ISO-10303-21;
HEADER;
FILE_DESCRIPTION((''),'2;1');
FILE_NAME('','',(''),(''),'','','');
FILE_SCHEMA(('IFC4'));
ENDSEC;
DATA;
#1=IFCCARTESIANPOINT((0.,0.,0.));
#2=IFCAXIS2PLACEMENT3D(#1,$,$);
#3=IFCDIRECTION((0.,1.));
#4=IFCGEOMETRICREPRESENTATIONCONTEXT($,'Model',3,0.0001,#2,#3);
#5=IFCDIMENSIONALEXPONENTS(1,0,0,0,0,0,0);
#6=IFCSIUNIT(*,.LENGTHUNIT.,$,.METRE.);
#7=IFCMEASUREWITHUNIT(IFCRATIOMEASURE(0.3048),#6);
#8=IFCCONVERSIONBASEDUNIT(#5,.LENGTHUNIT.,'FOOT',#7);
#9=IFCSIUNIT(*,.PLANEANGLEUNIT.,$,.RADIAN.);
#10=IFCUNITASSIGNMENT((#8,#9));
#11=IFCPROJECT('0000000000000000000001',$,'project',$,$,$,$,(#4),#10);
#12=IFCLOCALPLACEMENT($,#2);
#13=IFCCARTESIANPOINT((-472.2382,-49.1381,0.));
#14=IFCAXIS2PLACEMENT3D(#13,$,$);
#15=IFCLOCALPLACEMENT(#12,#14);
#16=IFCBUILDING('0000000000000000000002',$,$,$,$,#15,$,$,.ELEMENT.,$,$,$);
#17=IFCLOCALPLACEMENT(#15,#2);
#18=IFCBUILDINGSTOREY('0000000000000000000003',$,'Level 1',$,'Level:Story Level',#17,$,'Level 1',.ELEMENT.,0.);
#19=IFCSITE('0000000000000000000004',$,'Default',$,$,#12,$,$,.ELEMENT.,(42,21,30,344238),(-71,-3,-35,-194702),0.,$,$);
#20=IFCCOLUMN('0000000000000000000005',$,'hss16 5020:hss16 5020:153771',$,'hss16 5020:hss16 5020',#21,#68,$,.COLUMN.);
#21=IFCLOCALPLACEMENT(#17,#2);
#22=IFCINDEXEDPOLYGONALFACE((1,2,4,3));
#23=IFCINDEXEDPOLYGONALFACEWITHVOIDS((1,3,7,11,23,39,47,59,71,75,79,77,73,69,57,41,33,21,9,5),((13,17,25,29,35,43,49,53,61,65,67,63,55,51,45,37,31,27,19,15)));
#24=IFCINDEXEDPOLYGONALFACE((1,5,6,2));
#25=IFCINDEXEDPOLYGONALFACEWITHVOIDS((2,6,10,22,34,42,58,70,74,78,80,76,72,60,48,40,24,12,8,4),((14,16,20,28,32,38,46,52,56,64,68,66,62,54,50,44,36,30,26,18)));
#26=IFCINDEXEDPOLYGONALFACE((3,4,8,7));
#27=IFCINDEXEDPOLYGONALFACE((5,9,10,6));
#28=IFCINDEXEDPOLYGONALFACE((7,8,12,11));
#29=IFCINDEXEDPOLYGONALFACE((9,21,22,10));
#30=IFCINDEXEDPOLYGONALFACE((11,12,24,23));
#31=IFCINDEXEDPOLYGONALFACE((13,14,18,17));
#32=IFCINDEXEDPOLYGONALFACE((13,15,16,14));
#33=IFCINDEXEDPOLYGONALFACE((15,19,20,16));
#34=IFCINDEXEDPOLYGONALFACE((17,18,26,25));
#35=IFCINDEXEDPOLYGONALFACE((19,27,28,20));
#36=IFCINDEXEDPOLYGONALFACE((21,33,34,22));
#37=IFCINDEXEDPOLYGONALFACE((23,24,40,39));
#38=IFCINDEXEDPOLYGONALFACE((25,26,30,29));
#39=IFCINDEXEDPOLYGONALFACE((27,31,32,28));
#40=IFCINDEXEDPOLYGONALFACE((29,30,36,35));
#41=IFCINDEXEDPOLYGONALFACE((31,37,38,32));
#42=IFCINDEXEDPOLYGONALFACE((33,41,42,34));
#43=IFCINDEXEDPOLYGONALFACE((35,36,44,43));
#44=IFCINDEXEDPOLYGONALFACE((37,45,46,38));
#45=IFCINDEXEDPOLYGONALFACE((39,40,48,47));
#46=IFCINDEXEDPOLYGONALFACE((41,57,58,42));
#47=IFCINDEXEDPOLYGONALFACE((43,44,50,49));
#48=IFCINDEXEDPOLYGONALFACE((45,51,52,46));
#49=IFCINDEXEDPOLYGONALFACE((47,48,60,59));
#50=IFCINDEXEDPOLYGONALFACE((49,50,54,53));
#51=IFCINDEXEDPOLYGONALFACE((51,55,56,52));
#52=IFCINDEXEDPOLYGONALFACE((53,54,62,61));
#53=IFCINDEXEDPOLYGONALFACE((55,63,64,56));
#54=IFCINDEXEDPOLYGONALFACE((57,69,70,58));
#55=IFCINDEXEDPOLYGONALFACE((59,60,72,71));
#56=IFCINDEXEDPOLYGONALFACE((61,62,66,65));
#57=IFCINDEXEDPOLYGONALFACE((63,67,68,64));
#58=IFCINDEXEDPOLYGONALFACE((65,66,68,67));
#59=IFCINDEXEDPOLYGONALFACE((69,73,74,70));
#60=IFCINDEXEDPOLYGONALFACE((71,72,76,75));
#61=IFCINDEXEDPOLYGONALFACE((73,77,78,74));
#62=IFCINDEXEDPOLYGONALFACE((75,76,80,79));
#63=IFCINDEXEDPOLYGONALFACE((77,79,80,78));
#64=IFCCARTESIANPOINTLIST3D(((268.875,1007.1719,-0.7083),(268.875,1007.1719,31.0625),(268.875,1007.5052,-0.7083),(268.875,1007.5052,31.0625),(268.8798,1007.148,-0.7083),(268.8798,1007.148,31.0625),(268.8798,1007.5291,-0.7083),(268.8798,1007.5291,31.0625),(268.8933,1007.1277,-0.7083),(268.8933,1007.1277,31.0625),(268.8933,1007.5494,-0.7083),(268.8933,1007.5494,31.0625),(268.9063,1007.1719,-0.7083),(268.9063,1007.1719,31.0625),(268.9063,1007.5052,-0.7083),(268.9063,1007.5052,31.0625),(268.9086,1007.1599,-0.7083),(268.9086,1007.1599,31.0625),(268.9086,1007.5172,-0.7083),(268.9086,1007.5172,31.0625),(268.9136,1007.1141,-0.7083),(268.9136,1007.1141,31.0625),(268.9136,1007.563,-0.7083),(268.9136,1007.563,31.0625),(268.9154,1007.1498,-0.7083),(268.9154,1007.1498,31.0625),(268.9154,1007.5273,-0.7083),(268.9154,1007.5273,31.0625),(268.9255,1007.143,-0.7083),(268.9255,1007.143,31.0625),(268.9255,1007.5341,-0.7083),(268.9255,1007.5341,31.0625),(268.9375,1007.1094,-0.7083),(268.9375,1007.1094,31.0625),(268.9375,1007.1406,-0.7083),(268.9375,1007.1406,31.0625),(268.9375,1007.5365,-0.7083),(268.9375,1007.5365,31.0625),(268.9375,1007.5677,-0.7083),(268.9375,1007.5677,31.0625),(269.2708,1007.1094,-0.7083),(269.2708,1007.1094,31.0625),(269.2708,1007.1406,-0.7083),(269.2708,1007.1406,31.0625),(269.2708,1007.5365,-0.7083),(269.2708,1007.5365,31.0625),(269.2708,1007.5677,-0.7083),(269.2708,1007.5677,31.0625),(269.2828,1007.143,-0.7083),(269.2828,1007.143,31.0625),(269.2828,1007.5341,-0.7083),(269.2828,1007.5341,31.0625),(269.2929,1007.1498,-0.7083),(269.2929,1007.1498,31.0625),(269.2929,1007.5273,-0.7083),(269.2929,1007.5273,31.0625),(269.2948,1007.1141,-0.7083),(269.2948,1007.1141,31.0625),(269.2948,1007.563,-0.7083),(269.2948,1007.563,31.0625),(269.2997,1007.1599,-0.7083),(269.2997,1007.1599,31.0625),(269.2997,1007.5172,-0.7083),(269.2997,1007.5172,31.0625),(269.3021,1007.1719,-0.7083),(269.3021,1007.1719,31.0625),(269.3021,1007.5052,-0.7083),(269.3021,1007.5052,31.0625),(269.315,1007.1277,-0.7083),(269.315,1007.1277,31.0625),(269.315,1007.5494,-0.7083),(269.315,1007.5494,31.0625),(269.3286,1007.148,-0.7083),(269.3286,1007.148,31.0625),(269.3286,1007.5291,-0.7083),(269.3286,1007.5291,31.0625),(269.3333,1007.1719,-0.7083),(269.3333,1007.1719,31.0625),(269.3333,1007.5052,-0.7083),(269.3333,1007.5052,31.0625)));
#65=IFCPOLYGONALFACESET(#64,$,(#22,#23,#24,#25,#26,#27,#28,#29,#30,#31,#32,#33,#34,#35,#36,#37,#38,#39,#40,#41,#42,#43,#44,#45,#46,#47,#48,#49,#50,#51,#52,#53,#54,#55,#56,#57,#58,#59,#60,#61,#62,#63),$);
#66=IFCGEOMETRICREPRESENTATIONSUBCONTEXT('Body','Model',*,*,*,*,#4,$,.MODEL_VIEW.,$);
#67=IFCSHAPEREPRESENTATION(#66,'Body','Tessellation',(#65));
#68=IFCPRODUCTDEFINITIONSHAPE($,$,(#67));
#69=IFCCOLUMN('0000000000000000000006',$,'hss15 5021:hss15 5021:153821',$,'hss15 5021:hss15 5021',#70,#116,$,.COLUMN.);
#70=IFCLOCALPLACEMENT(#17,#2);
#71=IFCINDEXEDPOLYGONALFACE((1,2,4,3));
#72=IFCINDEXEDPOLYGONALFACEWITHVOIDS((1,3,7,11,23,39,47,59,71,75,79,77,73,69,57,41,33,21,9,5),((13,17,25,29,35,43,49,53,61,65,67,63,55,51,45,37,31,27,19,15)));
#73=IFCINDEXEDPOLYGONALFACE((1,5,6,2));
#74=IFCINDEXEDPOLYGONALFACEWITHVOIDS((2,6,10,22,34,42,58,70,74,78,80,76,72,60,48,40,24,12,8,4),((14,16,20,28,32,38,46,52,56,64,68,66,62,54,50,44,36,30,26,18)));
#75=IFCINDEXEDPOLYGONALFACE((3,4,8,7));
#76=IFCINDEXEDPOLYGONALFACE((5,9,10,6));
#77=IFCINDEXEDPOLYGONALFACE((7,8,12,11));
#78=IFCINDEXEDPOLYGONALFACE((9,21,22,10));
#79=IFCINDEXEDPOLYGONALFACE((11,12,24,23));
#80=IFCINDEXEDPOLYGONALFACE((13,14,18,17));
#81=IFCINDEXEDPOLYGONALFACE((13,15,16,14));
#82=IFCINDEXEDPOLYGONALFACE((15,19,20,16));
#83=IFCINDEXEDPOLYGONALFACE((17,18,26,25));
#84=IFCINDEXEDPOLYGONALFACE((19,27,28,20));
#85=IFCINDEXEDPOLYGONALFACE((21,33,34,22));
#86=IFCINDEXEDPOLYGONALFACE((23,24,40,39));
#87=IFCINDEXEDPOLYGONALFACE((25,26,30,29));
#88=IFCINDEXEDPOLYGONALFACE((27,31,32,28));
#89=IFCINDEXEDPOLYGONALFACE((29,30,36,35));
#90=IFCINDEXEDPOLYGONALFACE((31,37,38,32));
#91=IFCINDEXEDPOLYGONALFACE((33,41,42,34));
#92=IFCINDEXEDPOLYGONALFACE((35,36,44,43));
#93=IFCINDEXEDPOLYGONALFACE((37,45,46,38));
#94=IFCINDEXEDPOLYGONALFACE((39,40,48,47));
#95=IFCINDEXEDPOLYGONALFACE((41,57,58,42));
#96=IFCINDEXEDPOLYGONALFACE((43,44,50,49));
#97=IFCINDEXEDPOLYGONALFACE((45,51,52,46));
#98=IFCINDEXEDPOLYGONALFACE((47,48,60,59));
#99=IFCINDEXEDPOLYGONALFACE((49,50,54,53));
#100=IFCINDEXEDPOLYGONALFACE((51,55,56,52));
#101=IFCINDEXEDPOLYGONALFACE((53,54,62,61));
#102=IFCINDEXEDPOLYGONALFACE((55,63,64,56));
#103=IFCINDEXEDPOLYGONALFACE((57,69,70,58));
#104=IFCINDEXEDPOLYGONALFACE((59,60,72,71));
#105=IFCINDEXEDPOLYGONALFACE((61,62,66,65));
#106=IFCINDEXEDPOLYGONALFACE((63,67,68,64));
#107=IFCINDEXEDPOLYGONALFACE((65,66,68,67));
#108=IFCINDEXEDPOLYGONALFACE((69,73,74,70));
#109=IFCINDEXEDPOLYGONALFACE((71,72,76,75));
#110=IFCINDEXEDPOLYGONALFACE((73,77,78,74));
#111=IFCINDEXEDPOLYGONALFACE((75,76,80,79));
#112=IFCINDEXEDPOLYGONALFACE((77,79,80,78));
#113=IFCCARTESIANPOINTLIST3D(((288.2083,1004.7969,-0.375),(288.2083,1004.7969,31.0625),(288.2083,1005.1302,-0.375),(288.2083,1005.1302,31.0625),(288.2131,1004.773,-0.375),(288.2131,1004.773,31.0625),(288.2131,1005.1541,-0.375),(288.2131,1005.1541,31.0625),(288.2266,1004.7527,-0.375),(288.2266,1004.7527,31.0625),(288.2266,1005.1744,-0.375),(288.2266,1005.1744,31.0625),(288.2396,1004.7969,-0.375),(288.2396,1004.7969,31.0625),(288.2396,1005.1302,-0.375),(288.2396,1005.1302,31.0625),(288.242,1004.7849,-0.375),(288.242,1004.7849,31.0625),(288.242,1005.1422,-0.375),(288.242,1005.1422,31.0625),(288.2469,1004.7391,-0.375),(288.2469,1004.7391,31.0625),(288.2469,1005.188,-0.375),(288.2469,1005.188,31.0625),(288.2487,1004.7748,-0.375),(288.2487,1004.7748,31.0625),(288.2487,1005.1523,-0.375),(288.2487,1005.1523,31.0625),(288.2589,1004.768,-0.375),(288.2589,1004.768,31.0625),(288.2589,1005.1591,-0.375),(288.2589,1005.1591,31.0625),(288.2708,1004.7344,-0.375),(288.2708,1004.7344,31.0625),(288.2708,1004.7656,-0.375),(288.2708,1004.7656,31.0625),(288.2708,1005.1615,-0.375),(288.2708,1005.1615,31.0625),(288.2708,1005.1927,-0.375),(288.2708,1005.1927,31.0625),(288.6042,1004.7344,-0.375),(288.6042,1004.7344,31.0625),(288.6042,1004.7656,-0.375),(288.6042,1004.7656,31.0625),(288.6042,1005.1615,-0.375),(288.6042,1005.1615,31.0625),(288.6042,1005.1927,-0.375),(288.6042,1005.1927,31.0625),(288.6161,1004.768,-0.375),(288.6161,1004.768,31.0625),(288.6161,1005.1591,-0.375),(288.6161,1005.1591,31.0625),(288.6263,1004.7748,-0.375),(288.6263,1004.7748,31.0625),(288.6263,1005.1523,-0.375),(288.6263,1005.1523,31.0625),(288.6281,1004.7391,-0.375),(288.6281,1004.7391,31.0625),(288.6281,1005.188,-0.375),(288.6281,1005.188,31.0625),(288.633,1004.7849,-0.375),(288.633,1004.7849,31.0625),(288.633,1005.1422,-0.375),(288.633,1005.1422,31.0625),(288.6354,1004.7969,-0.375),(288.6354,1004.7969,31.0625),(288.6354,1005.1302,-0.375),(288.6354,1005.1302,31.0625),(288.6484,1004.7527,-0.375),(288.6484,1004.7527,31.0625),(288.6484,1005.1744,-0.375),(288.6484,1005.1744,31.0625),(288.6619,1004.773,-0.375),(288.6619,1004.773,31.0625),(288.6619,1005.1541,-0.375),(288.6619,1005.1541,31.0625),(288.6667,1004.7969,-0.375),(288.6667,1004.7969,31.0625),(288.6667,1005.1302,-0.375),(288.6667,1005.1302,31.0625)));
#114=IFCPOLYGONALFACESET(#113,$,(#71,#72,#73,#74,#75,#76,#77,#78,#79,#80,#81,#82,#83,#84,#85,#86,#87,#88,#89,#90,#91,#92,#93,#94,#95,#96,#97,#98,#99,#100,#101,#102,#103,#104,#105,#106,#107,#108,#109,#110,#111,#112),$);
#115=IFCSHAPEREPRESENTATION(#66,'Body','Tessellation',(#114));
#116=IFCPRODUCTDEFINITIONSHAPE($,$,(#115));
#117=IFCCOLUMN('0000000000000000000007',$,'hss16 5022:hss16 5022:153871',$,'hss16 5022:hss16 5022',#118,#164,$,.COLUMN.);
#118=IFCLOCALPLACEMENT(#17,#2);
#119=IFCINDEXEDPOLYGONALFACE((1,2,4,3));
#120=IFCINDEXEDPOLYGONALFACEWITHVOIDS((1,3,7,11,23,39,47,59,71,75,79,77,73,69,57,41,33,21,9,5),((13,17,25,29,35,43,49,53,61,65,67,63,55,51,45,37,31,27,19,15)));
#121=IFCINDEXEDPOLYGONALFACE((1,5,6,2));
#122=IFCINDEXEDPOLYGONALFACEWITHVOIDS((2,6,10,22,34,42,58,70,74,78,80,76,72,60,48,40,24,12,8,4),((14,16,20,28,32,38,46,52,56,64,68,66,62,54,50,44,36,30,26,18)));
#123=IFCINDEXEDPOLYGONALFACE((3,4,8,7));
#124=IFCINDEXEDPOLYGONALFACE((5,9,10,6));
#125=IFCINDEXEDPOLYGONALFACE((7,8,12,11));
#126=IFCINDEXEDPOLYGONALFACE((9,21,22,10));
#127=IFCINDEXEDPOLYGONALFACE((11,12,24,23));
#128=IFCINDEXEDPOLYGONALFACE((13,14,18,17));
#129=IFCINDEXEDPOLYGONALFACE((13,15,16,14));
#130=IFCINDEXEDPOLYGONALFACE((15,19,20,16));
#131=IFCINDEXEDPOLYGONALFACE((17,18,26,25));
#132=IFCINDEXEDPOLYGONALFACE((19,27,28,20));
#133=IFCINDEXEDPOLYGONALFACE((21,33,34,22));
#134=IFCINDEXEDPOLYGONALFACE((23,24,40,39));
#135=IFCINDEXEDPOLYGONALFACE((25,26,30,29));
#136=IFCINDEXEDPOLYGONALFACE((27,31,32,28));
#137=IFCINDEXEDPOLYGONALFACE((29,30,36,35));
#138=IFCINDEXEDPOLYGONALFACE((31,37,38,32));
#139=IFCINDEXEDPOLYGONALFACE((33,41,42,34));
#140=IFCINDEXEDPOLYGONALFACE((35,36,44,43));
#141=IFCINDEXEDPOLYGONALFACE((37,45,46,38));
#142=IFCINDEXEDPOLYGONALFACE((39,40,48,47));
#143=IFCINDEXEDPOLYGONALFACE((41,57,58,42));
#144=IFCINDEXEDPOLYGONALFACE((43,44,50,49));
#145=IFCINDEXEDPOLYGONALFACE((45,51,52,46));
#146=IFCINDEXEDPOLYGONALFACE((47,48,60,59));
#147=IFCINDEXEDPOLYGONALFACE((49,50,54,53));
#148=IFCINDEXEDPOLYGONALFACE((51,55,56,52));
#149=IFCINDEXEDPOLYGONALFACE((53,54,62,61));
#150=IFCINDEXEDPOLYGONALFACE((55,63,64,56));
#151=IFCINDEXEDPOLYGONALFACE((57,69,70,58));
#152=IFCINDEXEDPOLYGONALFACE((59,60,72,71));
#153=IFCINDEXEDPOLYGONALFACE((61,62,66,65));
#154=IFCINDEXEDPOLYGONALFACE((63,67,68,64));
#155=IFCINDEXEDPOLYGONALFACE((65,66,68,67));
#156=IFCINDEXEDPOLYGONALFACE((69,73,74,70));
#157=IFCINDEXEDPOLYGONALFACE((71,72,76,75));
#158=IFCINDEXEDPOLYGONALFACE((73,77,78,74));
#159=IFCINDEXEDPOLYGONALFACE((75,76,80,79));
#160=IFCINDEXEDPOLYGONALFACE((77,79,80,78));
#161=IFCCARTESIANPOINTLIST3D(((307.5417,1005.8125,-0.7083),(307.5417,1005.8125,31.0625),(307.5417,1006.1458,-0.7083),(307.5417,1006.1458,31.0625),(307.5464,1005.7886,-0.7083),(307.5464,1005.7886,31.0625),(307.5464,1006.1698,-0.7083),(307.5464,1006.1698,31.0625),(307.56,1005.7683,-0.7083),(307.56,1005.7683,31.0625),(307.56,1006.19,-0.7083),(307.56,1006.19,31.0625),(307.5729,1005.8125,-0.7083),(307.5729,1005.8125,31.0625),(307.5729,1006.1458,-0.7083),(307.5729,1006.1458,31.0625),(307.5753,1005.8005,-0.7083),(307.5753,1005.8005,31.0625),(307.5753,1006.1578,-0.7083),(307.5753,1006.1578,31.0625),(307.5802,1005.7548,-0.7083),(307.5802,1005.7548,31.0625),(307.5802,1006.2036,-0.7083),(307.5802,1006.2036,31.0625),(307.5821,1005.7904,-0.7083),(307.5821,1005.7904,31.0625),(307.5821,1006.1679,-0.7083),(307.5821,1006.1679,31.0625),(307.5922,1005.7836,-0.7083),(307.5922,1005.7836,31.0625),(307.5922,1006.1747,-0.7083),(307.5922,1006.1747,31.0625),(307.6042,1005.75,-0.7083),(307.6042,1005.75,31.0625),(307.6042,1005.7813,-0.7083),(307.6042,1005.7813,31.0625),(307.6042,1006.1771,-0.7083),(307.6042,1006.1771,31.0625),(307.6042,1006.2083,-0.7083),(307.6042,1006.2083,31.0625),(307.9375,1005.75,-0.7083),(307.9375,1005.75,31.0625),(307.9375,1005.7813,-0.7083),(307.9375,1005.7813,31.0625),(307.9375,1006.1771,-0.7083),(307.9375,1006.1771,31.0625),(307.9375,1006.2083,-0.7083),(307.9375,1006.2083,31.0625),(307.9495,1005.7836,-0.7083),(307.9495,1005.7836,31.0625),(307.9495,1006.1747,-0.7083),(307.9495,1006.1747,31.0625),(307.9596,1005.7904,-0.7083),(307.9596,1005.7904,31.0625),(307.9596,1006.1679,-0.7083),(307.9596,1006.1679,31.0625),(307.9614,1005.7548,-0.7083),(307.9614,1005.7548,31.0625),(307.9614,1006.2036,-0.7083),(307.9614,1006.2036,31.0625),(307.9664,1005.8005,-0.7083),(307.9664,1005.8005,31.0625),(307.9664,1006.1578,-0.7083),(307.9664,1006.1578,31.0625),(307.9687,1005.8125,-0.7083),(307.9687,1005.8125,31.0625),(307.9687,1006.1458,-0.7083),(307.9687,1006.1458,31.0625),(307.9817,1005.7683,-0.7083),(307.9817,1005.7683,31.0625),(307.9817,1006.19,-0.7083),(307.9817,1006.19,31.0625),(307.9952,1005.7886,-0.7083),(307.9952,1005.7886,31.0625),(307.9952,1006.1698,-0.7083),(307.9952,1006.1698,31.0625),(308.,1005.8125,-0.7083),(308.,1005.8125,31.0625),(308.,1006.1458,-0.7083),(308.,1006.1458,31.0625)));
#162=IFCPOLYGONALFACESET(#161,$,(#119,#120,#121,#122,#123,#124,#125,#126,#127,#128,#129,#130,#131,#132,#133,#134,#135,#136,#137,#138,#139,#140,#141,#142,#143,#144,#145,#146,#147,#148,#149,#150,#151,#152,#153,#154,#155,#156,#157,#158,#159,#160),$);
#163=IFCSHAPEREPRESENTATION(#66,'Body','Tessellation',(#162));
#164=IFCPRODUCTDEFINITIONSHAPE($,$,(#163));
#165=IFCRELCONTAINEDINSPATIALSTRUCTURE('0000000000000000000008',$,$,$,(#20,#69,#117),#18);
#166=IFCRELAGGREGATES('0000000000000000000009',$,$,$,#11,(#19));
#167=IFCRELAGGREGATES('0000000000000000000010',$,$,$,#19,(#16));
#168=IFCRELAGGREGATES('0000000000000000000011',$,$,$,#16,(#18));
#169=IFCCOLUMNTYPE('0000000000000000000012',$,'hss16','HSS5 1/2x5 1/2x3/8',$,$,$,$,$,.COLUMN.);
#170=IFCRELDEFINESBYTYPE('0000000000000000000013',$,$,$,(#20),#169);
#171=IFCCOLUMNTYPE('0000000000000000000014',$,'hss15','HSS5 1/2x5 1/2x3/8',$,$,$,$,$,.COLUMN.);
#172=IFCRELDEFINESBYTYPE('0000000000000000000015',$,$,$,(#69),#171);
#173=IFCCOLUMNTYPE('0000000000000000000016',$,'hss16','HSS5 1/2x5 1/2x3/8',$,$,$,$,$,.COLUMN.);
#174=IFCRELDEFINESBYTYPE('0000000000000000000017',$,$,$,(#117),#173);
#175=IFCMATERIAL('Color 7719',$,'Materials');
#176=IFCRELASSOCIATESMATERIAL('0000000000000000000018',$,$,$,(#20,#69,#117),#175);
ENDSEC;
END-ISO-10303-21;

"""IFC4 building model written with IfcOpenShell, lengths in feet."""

from ifc_helpers import new_model, entity, si_unit, converted_unit, direction, frame, origin, place, context, subcontext, project, spatial, polyline, outline, extrude, boolean, source, transform, mapped, material, type_object, type_shapes, element, save


model = new_model("IFC4")

# Units and contexts
model_context = context("Model", 3, precision=0.0001, world=origin(), true_north=direction((0.0, 1.0)))
body_context = subcontext(model_context, "Body", "Model", "MODEL_VIEW")
ifc_project = project(units=[converted_unit("LENGTHUNIT", "FOOT", entity("IfcRatioMeasure", 0.3048), si_unit("LENGTHUNIT", "METRE"), dimensions=[1, 0, 0, 0, 0, 0, 0]), si_unit("PLANEANGLEUNIT", "RADIAN")], contexts=[model_context])

# Site, building, storey
site_placement = place(None, origin())
site = spatial("IfcSite", under=ifc_project, at=site_placement, Name="Default", CompositionType="ELEMENT", RefLatitude=(42, 21, 30, 344238), RefLongitude=(-71, -3, -35, -194702), RefElevation=0.0)
building_placement = place(site_placement, frame((-472.2382, -49.1381, 0.0)))
building = spatial("IfcBuilding", under=site, at=building_placement, CompositionType="ELEMENT")
storey_placement = place(building_placement, origin())
storey = spatial("IfcBuildingStorey", under=building, at=storey_placement, Name="Level 1", ObjectType="Level:Story Level", LongName="Level 1", CompositionType="ELEMENT", Elevation=0.0)

# Columns
ifc_material_1 = material(Name="Color 7719", Category="Materials")
column_type_1 = type_object("IfcColumnType", Name="hss16", Description="HSS5 1/2x5 1/2x3/8", PredefinedType="COLUMN")
shared_shape_1 = source(origin(), body_context, "Body", "CSG", [
    boolean("DIFFERENCE", extrude(outline(polyline([(-0.1667, -0.2292), (0.1667, -0.2292), (0.1906, -0.2244), (0.2109, -0.2109), (0.2244, -0.1906), (0.2292, -0.1667), (0.2292, 0.1667), (0.2244, 0.1906), (0.2109, 0.2109), (0.1906, 0.2244), (0.1667, 0.2292), (-0.1667, 0.2292), (-0.1906, 0.2244), (-0.2109, 0.2109), (-0.2244, 0.1906), (-0.2292, 0.1667), (-0.2292, -0.1667), (-0.2244, -0.1906), (-0.2109, -0.2109), (-0.1906, -0.2244), (-0.1667, -0.2292)])), frame((269.1042, 1007.3385, -0.7083), z_axis=(0.0, 0.0, 1.0), x_axis=(0.0, -1.0, 0.0)), (0.0, 0.0, 1.0), 31.7708), extrude(outline(polyline([(-0.1667, -0.1979), (0.1667, -0.1979), (0.1786, -0.1955), (0.1888, -0.1888), (0.1955, -0.1786), (0.1979, -0.1667), (0.1979, 0.1667), (0.1955, 0.1786), (0.1888, 0.1888), (0.1786, 0.1955), (0.1667, 0.1979), (-0.1667, 0.1979), (-0.1786, 0.1955), (-0.1888, 0.1888), (-0.1955, 0.1786), (-0.1979, 0.1667), (-0.1979, -0.1667), (-0.1955, -0.1786), (-0.1888, -0.1888), (-0.1786, -0.1955), (-0.1667, -0.1979)])), frame((269.1042, 1007.3385, 31.0625), z_axis=(0.0, 0.0, -1.0), x_axis=(0.0, -1.0, 0.0)), (0.0, 0.0, 1.0), 31.7708)),
])
type_shapes(column_type_1, [shared_shape_1])
column_1_placement = place(building_placement, origin())
element("IfcColumn", 1, at=column_1_placement, inside=storey, type_object=column_type_1, material=ifc_material_1, Name="hss16 5020:hss16 5020:153771", ObjectType="hss16 5020:hss16 5020", PredefinedType="COLUMN", context=body_context, shape_type="MappedRepresentation", body=[
    mapped(shared_shape_1, transform((0.0, 0.0, 0.0), scale=1.0)),
])
column_type_2 = type_object("IfcColumnType", Name="hss15", Description="HSS5 1/2x5 1/2x3/8", PredefinedType="COLUMN")
shared_shape_2 = source(origin(), body_context, "Body", "CSG", [
    boolean("DIFFERENCE", extrude(outline(polyline([(-0.1667, -0.2292), (0.1667, -0.2292), (0.1906, -0.2244), (0.2109, -0.2109), (0.2244, -0.1906), (0.2292, -0.1667), (0.2292, 0.1667), (0.2244, 0.1906), (0.2109, 0.2109), (0.1906, 0.2244), (0.1667, 0.2292), (-0.1667, 0.2292), (-0.1906, 0.2244), (-0.2109, 0.2109), (-0.2244, 0.1906), (-0.2292, 0.1667), (-0.2292, -0.1667), (-0.2244, -0.1906), (-0.2109, -0.2109), (-0.1906, -0.2244), (-0.1667, -0.2292)])), frame((288.4375, 1004.9635, -0.375), z_axis=(0.0, 0.0, 1.0), x_axis=(0.0, -1.0, 0.0)), (0.0, 0.0, 1.0), 31.4375), extrude(outline(polyline([(-0.1667, -0.1979), (0.1667, -0.1979), (0.1786, -0.1955), (0.1888, -0.1888), (0.1955, -0.1786), (0.1979, -0.1667), (0.1979, 0.1667), (0.1955, 0.1786), (0.1888, 0.1888), (0.1786, 0.1955), (0.1667, 0.1979), (-0.1667, 0.1979), (-0.1786, 0.1955), (-0.1888, 0.1888), (-0.1955, 0.1786), (-0.1979, 0.1667), (-0.1979, -0.1667), (-0.1955, -0.1786), (-0.1888, -0.1888), (-0.1786, -0.1955), (-0.1667, -0.1979)])), frame((288.4375, 1004.9635, 31.0625), z_axis=(0.0, 0.0, -1.0), x_axis=(0.0, -1.0, 0.0)), (0.0, 0.0, 1.0), 31.4375)),
])
type_shapes(column_type_2, [shared_shape_2])
column_2_placement = place(building_placement, origin())
element("IfcColumn", 2, at=column_2_placement, inside=storey, type_object=column_type_2, material=ifc_material_1, Name="hss15 5021:hss15 5021:153821", ObjectType="hss15 5021:hss15 5021", PredefinedType="COLUMN", context=body_context, shape_type="MappedRepresentation", body=[
    mapped(shared_shape_2, transform((0.0, 0.0, 0.0), scale=1.0)),
])
column_type_3 = type_object("IfcColumnType", Name="hss16", Description="HSS5 1/2x5 1/2x3/8", PredefinedType="COLUMN")
shared_shape_3 = source(origin(), body_context, "Body", "CSG", [
    boolean("DIFFERENCE", extrude(outline(polyline([(-0.1667, -0.2292), (0.1667, -0.2292), (0.1906, -0.2244), (0.2109, -0.2109), (0.2244, -0.1906), (0.2292, -0.1667), (0.2292, 0.1667), (0.2244, 0.1906), (0.2109, 0.2109), (0.1906, 0.2244), (0.1667, 0.2292), (-0.1667, 0.2292), (-0.1906, 0.2244), (-0.2109, 0.2109), (-0.2244, 0.1906), (-0.2292, 0.1667), (-0.2292, -0.1667), (-0.2244, -0.1906), (-0.2109, -0.2109), (-0.1906, -0.2244), (-0.1667, -0.2292)])), frame((307.7708, 1005.9792, -0.7083), z_axis=(0.0, 0.0, 1.0), x_axis=(0.0, -1.0, 0.0)), (0.0, 0.0, 1.0), 31.7708), extrude(outline(polyline([(-0.1667, -0.1979), (0.1667, -0.1979), (0.1786, -0.1955), (0.1888, -0.1888), (0.1955, -0.1786), (0.1979, -0.1667), (0.1979, 0.1667), (0.1955, 0.1786), (0.1888, 0.1888), (0.1786, 0.1955), (0.1667, 0.1979), (-0.1667, 0.1979), (-0.1786, 0.1955), (-0.1888, 0.1888), (-0.1955, 0.1786), (-0.1979, 0.1667), (-0.1979, -0.1667), (-0.1955, -0.1786), (-0.1888, -0.1888), (-0.1786, -0.1955), (-0.1667, -0.1979)])), frame((307.7708, 1005.9792, 31.0625), z_axis=(0.0, 0.0, -1.0), x_axis=(0.0, -1.0, 0.0)), (0.0, 0.0, 1.0), 31.7708)),
])
type_shapes(column_type_3, [shared_shape_3])
column_3_placement = place(building_placement, origin())
element("IfcColumn", 3, at=column_3_placement, inside=storey, type_object=column_type_3, material=ifc_material_1, Name="hss16 5022:hss16 5022:153871", ObjectType="hss16 5022:hss16 5022", PredefinedType="COLUMN", context=body_context, shape_type="MappedRepresentation", body=[
    mapped(shared_shape_3, transform((0.0, 0.0, 0.0), scale=1.0)),
])

save(model, "model.ifc")
